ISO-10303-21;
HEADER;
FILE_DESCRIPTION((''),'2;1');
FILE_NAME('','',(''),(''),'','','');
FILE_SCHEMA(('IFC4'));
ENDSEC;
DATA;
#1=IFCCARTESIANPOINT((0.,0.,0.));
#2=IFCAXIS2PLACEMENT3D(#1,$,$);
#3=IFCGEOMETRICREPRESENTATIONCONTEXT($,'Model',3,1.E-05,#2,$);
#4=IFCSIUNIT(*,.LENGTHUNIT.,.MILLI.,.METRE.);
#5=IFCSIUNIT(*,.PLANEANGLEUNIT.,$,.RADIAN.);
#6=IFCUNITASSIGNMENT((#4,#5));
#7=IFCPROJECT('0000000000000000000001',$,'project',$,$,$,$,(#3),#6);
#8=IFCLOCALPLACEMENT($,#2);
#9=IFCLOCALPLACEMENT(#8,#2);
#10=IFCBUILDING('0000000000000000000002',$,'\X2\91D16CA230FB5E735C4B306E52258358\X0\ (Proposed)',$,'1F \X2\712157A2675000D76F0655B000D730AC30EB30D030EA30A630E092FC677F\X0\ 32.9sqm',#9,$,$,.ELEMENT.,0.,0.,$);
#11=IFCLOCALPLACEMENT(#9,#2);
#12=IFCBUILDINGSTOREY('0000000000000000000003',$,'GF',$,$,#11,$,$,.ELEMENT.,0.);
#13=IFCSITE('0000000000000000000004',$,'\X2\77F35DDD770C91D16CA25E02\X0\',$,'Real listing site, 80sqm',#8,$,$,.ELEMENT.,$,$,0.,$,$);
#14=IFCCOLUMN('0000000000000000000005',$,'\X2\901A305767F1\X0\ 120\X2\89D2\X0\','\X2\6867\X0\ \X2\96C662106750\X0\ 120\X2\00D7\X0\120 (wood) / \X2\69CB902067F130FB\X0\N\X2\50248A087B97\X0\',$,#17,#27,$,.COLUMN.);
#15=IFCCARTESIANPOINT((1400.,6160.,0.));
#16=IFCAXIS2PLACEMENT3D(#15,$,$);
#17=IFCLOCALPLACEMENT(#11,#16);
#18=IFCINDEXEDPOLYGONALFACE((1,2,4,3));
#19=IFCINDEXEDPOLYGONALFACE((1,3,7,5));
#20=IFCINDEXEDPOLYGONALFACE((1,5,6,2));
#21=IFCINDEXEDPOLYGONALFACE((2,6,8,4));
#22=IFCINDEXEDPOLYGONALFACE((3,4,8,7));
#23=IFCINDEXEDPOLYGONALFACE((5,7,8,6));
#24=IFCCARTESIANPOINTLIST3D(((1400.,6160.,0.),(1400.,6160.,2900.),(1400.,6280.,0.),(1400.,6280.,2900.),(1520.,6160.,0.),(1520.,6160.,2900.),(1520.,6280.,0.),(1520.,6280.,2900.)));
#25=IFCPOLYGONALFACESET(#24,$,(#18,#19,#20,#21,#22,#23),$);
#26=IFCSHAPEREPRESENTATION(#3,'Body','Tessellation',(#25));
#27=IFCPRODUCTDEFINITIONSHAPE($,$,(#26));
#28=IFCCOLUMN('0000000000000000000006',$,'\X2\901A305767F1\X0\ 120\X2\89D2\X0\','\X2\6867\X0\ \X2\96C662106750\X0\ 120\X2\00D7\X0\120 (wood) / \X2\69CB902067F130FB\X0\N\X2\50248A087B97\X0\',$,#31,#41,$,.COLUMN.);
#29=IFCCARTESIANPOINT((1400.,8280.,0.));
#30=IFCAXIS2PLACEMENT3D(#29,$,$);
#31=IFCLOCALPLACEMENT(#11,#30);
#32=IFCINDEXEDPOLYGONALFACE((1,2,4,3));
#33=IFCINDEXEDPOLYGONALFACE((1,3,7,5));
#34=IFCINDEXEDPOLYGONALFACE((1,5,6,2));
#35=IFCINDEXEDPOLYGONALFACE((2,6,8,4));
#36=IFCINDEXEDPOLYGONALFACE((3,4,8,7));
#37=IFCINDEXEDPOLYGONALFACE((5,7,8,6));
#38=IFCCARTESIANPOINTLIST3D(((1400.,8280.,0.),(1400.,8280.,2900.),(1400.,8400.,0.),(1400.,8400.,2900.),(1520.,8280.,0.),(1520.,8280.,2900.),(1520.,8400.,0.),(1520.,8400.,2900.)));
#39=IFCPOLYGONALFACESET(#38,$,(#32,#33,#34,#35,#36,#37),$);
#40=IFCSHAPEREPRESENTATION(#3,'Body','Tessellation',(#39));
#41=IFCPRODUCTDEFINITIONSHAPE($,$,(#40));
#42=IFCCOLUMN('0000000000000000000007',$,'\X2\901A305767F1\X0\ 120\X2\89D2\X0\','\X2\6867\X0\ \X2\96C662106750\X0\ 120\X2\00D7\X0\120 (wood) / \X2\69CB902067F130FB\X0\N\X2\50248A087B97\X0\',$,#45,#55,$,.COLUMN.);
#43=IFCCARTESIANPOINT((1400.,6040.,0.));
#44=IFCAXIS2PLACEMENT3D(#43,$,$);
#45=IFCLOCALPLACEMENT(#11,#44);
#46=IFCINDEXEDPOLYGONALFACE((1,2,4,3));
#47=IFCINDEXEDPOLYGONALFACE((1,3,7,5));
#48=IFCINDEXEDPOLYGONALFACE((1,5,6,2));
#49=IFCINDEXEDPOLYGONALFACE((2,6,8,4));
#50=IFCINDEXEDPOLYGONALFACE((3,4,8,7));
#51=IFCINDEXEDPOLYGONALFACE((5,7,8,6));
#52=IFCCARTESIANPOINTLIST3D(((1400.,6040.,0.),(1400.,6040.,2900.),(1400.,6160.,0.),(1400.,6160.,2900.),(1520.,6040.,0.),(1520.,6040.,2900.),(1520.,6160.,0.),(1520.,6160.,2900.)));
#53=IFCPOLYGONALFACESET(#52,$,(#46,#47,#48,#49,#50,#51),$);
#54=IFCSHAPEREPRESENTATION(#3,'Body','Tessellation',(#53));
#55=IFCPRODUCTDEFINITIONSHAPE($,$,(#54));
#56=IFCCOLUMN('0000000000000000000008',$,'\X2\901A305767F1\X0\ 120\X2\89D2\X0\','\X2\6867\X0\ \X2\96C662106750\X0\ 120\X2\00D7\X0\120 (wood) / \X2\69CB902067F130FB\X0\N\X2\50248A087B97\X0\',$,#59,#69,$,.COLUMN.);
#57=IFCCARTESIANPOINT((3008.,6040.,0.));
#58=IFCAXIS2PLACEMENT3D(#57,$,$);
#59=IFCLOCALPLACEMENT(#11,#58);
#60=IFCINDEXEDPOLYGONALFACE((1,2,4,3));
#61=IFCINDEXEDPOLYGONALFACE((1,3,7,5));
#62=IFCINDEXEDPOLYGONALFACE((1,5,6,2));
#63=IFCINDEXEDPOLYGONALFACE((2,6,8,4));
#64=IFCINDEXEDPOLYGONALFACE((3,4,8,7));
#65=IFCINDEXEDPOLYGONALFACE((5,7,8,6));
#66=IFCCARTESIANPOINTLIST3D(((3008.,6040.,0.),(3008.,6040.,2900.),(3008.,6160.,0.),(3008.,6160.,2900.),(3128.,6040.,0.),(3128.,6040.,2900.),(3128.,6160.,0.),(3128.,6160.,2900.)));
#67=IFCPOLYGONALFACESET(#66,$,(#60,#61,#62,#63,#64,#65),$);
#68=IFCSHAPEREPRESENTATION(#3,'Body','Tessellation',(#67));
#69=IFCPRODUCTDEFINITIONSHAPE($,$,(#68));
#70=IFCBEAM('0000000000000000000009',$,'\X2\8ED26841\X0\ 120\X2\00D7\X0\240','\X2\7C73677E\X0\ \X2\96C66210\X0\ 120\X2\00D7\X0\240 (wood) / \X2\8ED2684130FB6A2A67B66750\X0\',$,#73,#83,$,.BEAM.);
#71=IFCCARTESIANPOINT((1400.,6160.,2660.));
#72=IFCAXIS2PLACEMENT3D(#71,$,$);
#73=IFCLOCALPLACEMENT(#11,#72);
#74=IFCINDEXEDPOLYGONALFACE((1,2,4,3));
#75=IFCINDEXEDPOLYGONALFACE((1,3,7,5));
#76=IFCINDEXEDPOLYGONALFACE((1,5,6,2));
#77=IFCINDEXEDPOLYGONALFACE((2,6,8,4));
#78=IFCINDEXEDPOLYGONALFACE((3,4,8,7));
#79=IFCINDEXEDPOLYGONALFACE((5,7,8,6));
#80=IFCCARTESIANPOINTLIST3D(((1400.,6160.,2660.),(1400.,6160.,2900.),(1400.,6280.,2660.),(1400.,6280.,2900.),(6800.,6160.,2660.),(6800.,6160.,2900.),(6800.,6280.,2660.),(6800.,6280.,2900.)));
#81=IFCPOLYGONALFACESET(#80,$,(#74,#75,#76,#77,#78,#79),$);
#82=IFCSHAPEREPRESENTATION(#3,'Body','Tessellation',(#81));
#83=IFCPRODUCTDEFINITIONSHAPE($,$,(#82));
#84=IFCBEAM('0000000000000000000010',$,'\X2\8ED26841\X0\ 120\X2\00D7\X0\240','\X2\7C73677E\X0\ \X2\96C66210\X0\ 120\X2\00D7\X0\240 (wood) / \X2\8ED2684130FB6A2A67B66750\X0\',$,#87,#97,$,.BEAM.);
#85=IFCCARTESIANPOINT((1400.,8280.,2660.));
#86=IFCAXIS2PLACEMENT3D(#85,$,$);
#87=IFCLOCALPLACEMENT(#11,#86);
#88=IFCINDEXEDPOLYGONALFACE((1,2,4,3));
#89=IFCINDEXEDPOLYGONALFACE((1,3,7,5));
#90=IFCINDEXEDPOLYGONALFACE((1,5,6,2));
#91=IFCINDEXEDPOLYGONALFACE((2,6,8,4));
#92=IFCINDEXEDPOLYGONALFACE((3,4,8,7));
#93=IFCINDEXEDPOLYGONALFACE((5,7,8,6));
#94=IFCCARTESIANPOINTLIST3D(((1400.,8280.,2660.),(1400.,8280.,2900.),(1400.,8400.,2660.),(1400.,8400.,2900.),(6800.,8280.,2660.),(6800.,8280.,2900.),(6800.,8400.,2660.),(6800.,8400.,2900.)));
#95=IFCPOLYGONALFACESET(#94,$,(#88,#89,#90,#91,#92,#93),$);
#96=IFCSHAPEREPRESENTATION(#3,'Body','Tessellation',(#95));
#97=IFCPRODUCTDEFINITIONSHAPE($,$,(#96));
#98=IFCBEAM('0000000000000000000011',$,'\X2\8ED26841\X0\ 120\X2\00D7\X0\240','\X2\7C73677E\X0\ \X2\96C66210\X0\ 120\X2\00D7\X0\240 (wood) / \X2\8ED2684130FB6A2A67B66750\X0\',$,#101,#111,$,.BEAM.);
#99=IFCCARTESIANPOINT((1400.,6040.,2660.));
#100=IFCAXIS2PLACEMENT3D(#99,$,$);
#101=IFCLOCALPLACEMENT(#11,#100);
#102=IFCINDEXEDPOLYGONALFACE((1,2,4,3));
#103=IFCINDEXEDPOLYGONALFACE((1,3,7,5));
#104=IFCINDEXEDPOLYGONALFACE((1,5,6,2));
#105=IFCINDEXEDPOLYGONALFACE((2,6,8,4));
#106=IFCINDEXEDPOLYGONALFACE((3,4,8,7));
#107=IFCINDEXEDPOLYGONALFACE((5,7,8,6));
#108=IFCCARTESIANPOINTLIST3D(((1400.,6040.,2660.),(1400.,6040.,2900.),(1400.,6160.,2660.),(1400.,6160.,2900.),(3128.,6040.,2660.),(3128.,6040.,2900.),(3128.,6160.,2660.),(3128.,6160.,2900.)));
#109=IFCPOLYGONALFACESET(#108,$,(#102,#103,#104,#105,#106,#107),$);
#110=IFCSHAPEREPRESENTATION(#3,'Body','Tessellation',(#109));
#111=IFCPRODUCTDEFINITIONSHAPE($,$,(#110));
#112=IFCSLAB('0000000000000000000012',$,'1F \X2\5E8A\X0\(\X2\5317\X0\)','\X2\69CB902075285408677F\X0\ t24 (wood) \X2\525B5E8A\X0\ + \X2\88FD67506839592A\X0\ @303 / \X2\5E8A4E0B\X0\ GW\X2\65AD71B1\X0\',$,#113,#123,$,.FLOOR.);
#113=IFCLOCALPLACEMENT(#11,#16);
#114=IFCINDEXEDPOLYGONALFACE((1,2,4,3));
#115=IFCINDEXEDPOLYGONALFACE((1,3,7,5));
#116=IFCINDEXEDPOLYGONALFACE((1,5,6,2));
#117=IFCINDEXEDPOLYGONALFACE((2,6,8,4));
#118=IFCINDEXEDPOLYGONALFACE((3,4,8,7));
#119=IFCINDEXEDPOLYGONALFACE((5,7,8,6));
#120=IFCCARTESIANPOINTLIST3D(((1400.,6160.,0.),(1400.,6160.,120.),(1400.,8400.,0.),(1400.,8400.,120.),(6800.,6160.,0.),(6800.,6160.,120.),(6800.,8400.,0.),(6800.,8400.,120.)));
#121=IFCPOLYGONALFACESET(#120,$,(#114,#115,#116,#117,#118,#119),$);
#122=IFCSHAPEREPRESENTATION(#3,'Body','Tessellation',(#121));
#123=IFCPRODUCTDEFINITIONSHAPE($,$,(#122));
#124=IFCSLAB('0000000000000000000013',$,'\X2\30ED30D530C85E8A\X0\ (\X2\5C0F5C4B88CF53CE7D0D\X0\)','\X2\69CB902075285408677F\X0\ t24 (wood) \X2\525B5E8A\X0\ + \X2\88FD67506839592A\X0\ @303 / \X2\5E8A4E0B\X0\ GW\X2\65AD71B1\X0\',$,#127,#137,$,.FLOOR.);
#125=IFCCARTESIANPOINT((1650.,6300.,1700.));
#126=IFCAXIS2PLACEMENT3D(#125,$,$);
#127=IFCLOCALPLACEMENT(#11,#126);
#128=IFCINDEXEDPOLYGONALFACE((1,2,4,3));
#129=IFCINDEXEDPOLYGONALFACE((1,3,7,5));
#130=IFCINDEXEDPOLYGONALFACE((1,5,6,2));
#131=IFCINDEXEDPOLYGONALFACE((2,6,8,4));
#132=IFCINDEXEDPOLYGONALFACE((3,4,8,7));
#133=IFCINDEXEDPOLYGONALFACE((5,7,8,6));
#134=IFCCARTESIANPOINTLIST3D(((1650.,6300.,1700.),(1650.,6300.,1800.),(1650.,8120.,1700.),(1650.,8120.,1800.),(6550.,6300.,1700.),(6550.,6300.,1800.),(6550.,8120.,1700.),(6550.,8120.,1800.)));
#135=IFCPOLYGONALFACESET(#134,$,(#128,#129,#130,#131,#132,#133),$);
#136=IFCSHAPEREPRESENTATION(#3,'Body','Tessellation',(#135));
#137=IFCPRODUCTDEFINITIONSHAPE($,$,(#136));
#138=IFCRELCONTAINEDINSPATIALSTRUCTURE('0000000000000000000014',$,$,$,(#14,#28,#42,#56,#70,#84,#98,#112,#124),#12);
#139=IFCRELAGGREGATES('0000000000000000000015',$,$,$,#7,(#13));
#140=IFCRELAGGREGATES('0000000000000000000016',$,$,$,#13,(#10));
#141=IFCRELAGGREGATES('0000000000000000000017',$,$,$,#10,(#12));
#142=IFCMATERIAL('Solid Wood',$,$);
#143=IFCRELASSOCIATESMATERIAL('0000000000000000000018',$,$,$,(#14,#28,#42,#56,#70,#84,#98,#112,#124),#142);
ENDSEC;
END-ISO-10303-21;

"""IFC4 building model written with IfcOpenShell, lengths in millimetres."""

from ifc_helpers import new_model, si_unit, frame, frame_2d, origin, place, context, project, spatial, rectangle, extrude, material, element, save


model = new_model("IFC4")

# Units and contexts
model_context = context("Model", 3, precision=1e-05, world=origin())
ifc_project = project(units=[si_unit("LENGTHUNIT", "METRE", prefix="MILLI"), si_unit("PLANEANGLEUNIT", "RADIAN")], contexts=[model_context])

# Site, building, storey
site_placement = place(None, origin())
site = spatial("IfcSite", under=ifc_project, at=site_placement, Name="石川県金沢市", ObjectType="Real listing site, 80sqm", CompositionType="ELEMENT", RefElevation=0.0)
building_placement = place(site_placement, origin())
building = spatial("IfcBuilding", under=site, at=building_placement, Name="金沢・平屋の別荘 (Proposed)", ObjectType="1F 無垢材×漆喰×ガルバリウム鋼板 32.9sqm", CompositionType="ELEMENT", ElevationOfRefHeight=0.0, ElevationOfTerrain=0.0)
storey_placement = place(building_placement, origin())
storey = spatial("IfcBuildingStorey", under=building, at=storey_placement, Name="GF", CompositionType="ELEMENT", Elevation=0.0)

# Columns
ifc_material_1 = material(Name="Solid Wood")
column_1_placement = place(storey_placement, frame((1400.0, 6160.0, 0.0)))
element("IfcColumn", 1, at=column_1_placement, inside=storey, material=ifc_material_1, Name="通し柱 120角", Description="桧 集成材 120×120 (wood) / 構造柱・N値計算", PredefinedType="COLUMN", context=model_context, shape_type="SweptSolid", body=[
    extrude(rectangle(XDim=120.0, YDim=120.0, at=frame_2d((60.0, 60.0))), frame((1400.0, 6160.0, 0.0)), (0.0, 0.0, 1.0), 2900.0),
])
column_2_placement = place(storey_placement, frame((1400.0, 8280.0, 0.0)))
element("IfcColumn", 2, at=column_2_placement, inside=storey, material=ifc_material_1, Name="通し柱 120角", Description="桧 集成材 120×120 (wood) / 構造柱・N値計算", PredefinedType="COLUMN", context=model_context, shape_type="SweptSolid", body=[
    extrude(rectangle(XDim=120.0, YDim=120.0, at=frame_2d((60.0, 60.0))), frame((1400.0, 8280.0, 0.0)), (0.0, 0.0, 1.0), 2900.0),
])
column_3_placement = place(storey_placement, frame((1400.0, 6040.0, 0.0)))
element("IfcColumn", 3, at=column_3_placement, inside=storey, material=ifc_material_1, Name="通し柱 120角", Description="桧 集成材 120×120 (wood) / 構造柱・N値計算", PredefinedType="COLUMN", context=model_context, shape_type="SweptSolid", body=[
    extrude(rectangle(XDim=120.0, YDim=120.0, at=frame_2d((60.0, 60.0))), frame((1400.0, 6040.0, 0.0)), (0.0, 0.0, 1.0), 2900.0),
])
column_4_placement = place(storey_placement, frame((3008.0, 6040.0, 0.0)))
element("IfcColumn", 4, at=column_4_placement, inside=storey, material=ifc_material_1, Name="通し柱 120角", Description="桧 集成材 120×120 (wood) / 構造柱・N値計算", PredefinedType="COLUMN", context=model_context, shape_type="SweptSolid", body=[
    extrude(rectangle(XDim=120.0, YDim=120.0, at=frame_2d((60.0, 60.0))), frame((3008.0, 6040.0, 0.0)), (0.0, 0.0, 1.0), 2900.0),
])

# Beams
beam_1_placement = place(storey_placement, frame((1400.0, 6160.0, 2660.0)))
element("IfcBeam", 5, at=beam_1_placement, inside=storey, material=ifc_material_1, Name="軒桁 120×240", Description="米松 集成 120×240 (wood) / 軒桁・横架材", PredefinedType="BEAM", context=model_context, shape_type="SweptSolid", body=[
    extrude(rectangle(XDim=5400.0, YDim=120.0, at=frame_2d((2700.0, 60.0))), frame((1400.0, 6160.0, 2660.0)), (0.0, 0.0, 1.0), 240.0),
])
beam_2_placement = place(storey_placement, frame((1400.0, 8280.0, 2660.0)))
element("IfcBeam", 6, at=beam_2_placement, inside=storey, material=ifc_material_1, Name="軒桁 120×240", Description="米松 集成 120×240 (wood) / 軒桁・横架材", PredefinedType="BEAM", context=model_context, shape_type="SweptSolid", body=[
    extrude(rectangle(XDim=5400.0, YDim=120.0, at=frame_2d((2700.0, 60.0))), frame((1400.0, 8280.0, 2660.0)), (0.0, 0.0, 1.0), 240.0),
])
beam_3_placement = place(storey_placement, frame((1400.0, 6040.0, 2660.0)))
element("IfcBeam", 7, at=beam_3_placement, inside=storey, material=ifc_material_1, Name="軒桁 120×240", Description="米松 集成 120×240 (wood) / 軒桁・横架材", PredefinedType="BEAM", context=model_context, shape_type="SweptSolid", body=[
    extrude(rectangle(XDim=1728.0, YDim=120.0, at=frame_2d((864.0, 60.0))), frame((1400.0, 6040.0, 2660.0)), (0.0, 0.0, 1.0), 240.0),
])

# Slabs
slab_1_placement = place(storey_placement, frame((1400.0, 6160.0, 0.0)))
element("IfcSlab", 8, at=slab_1_placement, inside=storey, material=ifc_material_1, Name="1F 床(北)", Description="構造用合板 t24 (wood) 剛床 + 製材根太 @303 / 床下 GW断熱", PredefinedType="FLOOR", context=model_context, shape_type="SweptSolid", body=[
    extrude(rectangle(XDim=5400.0, YDim=2240.0, at=frame_2d((2700.0, 1120.0))), frame((1400.0, 6160.0, 0.0)), (0.0, 0.0, 1.0), 120.0),
])
slab_2_placement = place(storey_placement, frame((1650.0, 6300.0, 1700.0)))
element("IfcSlab", 9, at=slab_2_placement, inside=storey, material=ifc_material_1, Name="ロフト床 (小屋裏収納)", Description="構造用合板 t24 (wood) 剛床 + 製材根太 @303 / 床下 GW断熱", PredefinedType="FLOOR", context=model_context, shape_type="SweptSolid", body=[
    extrude(rectangle(XDim=4900.0, YDim=1820.0, at=frame_2d((2450.0, 910.0))), frame((1650.0, 6300.0, 1700.0)), (0.0, 0.0, 1.0), 100.0),
])

save(model, "model.ifc")
